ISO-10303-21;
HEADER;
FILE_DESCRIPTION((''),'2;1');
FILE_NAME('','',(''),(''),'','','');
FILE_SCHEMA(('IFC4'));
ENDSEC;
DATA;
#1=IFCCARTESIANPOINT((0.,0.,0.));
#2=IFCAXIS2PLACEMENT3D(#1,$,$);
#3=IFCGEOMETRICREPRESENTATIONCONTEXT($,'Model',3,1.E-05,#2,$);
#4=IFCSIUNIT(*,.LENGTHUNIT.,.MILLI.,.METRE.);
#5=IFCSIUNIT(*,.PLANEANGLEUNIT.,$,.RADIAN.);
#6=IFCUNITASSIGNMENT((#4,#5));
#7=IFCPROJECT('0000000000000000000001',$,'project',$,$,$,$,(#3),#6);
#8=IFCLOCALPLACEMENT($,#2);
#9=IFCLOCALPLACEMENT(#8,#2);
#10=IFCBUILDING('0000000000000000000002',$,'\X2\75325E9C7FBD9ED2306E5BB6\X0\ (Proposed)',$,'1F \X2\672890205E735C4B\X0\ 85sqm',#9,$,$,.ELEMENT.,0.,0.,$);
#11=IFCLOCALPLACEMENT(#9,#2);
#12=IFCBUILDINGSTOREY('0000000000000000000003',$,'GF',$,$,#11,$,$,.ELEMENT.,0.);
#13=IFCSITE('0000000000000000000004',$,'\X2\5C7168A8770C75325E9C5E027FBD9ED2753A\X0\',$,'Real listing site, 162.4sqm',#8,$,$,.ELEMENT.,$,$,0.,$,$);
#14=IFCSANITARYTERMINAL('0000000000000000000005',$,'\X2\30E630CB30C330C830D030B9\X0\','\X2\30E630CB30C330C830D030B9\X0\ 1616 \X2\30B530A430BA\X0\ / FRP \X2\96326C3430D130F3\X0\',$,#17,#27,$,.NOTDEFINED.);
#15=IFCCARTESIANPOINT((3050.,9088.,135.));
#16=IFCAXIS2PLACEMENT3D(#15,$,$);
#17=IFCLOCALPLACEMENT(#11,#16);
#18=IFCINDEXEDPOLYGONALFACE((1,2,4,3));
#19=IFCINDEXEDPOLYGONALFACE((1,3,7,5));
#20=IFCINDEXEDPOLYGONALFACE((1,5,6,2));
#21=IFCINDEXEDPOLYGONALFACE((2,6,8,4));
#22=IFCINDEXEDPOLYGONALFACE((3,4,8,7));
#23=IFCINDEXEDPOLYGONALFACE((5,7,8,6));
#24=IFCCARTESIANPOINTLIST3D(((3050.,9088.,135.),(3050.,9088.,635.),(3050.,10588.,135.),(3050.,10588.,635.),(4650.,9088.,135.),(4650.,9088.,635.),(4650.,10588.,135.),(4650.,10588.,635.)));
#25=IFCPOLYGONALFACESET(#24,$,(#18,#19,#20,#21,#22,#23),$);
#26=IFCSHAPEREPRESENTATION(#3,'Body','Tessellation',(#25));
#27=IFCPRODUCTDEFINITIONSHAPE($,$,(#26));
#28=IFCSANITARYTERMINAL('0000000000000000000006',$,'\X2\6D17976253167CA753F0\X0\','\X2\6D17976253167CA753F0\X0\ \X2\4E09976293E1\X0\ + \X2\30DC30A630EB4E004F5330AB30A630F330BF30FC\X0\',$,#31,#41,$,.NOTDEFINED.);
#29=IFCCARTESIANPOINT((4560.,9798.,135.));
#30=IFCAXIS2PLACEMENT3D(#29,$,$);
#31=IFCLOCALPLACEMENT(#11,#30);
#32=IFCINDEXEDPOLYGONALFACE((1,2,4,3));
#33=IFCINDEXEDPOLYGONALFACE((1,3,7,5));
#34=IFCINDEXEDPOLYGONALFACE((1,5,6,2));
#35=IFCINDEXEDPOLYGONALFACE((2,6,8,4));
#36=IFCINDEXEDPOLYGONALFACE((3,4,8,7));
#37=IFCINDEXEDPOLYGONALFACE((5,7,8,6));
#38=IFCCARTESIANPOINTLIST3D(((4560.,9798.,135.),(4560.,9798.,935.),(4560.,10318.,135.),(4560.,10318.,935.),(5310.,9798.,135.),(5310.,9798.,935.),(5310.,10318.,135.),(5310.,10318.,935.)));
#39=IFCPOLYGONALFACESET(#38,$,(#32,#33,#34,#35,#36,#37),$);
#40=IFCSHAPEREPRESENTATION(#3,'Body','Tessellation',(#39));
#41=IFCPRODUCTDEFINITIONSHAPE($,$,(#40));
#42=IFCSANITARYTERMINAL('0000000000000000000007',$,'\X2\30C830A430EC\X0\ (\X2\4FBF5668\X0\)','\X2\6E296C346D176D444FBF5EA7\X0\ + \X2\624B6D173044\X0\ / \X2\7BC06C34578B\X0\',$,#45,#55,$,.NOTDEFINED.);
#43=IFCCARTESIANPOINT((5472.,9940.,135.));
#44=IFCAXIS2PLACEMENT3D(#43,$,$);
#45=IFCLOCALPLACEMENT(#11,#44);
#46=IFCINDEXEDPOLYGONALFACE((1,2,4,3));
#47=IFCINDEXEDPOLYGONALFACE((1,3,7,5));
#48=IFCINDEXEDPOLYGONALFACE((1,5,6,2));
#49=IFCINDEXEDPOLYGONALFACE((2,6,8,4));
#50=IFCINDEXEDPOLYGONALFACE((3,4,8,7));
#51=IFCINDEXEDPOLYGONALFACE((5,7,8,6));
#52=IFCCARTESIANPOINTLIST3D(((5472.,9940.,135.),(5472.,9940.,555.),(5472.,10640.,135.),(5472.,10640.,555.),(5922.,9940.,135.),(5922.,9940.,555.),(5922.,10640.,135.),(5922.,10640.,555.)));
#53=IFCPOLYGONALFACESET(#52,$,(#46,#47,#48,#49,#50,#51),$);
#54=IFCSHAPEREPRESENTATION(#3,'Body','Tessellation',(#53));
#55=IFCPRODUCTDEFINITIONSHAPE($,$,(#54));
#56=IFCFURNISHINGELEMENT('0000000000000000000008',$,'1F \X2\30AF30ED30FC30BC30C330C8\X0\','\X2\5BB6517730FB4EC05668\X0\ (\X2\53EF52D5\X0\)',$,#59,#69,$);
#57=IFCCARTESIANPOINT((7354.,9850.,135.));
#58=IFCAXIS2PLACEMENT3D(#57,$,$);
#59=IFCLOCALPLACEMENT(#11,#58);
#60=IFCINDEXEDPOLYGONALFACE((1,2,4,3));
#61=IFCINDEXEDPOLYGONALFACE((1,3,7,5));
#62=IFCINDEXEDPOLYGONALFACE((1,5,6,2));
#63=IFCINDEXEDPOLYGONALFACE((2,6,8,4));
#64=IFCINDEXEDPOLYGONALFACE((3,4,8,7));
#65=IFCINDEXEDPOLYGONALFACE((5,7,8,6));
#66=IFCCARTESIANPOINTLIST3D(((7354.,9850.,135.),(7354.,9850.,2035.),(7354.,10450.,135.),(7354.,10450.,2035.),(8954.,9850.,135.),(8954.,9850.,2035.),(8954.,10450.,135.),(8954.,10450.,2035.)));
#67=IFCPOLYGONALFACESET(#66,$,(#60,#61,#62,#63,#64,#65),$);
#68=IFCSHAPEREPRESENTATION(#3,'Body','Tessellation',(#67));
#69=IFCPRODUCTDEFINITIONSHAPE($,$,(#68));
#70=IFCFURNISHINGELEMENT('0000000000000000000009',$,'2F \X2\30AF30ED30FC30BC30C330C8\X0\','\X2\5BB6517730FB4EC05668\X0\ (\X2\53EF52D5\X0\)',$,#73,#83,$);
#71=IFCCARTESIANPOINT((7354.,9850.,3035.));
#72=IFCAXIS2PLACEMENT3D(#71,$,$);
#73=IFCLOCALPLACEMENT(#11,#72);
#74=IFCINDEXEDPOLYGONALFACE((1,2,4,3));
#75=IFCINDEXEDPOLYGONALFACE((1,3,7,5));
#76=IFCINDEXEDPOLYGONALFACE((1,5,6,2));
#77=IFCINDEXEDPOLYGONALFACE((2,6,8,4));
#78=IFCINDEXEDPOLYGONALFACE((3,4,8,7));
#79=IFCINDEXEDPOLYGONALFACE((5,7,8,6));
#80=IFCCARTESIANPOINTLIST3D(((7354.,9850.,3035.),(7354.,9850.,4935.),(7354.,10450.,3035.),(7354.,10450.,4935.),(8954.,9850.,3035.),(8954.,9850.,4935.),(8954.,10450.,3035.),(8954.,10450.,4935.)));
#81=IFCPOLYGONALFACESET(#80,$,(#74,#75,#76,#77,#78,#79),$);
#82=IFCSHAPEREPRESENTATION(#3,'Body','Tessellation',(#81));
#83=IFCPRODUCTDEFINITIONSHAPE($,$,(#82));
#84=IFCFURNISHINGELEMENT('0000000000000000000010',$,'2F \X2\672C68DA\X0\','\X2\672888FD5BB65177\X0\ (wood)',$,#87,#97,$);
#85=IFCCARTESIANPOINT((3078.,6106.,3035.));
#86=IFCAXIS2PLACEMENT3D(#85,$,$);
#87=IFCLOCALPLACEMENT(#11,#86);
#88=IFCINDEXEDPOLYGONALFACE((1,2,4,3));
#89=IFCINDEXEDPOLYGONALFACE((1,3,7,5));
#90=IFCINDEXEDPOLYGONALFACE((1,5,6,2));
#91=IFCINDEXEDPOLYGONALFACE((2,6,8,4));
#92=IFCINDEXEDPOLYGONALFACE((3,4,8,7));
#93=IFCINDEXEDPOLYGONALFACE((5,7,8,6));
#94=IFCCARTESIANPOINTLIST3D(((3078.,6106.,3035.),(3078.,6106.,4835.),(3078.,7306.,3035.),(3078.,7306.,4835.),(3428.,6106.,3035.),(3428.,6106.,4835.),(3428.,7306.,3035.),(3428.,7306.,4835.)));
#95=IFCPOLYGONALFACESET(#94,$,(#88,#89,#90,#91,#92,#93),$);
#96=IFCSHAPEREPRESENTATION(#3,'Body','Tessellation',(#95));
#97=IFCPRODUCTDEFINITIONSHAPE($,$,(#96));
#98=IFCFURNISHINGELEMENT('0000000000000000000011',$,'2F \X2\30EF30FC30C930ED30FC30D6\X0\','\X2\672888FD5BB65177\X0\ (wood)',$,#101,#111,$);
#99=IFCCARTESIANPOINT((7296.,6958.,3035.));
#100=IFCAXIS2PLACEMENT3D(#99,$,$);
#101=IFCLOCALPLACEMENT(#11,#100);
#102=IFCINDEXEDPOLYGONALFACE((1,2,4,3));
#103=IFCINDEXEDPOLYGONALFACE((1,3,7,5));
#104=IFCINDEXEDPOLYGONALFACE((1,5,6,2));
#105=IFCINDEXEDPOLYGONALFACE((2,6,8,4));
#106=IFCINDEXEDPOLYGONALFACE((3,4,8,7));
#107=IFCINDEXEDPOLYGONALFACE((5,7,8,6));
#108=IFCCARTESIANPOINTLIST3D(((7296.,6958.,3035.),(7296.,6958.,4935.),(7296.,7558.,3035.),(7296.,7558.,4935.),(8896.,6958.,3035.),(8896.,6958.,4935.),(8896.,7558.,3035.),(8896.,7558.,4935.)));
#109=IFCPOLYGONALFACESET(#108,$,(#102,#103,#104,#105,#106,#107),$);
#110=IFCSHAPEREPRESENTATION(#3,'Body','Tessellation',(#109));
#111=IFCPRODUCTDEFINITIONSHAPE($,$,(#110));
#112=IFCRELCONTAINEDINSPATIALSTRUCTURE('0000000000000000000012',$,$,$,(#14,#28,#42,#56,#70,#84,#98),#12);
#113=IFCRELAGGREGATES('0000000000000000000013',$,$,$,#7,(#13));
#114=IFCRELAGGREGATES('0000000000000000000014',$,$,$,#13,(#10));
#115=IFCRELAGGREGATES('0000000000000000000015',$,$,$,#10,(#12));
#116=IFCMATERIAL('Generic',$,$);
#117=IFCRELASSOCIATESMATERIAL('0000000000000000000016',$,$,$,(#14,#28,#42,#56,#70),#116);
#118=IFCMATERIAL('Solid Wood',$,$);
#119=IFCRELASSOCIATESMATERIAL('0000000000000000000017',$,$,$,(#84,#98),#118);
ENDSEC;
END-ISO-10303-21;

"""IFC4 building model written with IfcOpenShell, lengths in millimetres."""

from ifc_helpers import new_model, si_unit, frame, frame_2d, origin, place, context, project, spatial, rectangle, extrude, material, element, save


model = new_model("IFC4")

# Units and contexts
model_context = context("Model", 3, precision=1e-05, world=origin())
ifc_project = project(units=[si_unit("LENGTHUNIT", "METRE", prefix="MILLI"), si_unit("PLANEANGLEUNIT", "RADIAN")], contexts=[model_context])

# Site, building, storey
site_placement = place(None, origin())
site = spatial("IfcSite", under=ifc_project, at=site_placement, Name="山梨県甲府市羽黒町", ObjectType="Real listing site, 162.4sqm", CompositionType="ELEMENT", RefElevation=0.0)
building_placement = place(site_placement, origin())
building = spatial("IfcBuilding", under=site, at=building_placement, Name="甲府羽黒の家 (Proposed)", ObjectType="1F 木造平屋 85sqm", CompositionType="ELEMENT", ElevationOfRefHeight=0.0, ElevationOfTerrain=0.0)
storey_placement = place(building_placement, origin())
storey = spatial("IfcBuildingStorey", under=building, at=storey_placement, Name="GF", CompositionType="ELEMENT", Elevation=0.0)

# Shared definitions
ifc_material_1 = material(Name="Solid Wood")

# Shared definitions
ifc_material_2 = material(Name="Generic")

# Sanitary terminals
sanitary_terminal_1_placement = place(storey_placement, frame((3050.0, 9088.0, 135.0)))
element("IfcSanitaryTerminal", 1, at=sanitary_terminal_1_placement, inside=storey, material=ifc_material_2, Name="ユニットバス", Description="ユニットバス 1616 サイズ / FRP 防水パン", PredefinedType="NOTDEFINED", context=model_context, shape_type="SweptSolid", body=[
    extrude(rectangle(XDim=1600.0, YDim=1500.0, at=frame_2d((800.0, 750.0))), frame((3050.0, 9088.0, 135.0)), (0.0, 0.0, 1.0), 500.0),
])
sanitary_terminal_2_placement = place(storey_placement, frame((4560.0, 9798.0, 135.0)))
element("IfcSanitaryTerminal", 2, at=sanitary_terminal_2_placement, inside=storey, material=ifc_material_2, Name="洗面化粧台", Description="洗面化粧台 三面鏡 + ボウル一体カウンター", PredefinedType="NOTDEFINED", context=model_context, shape_type="SweptSolid", body=[
    extrude(rectangle(XDim=750.0, YDim=520.0, at=frame_2d((375.0, 260.0))), frame((4560.0, 9798.0, 135.0)), (0.0, 0.0, 1.0), 800.0),
])
sanitary_terminal_3_placement = place(storey_placement, frame((5472.0, 9940.0, 135.0)))
element("IfcSanitaryTerminal", 3, at=sanitary_terminal_3_placement, inside=storey, material=ifc_material_2, Name="トイレ (便器)", Description="温水洗浄便座 + 手洗い / 節水型", PredefinedType="NOTDEFINED", context=model_context, shape_type="SweptSolid", body=[
    extrude(rectangle(XDim=450.0, YDim=700.0, at=frame_2d((225.0, 350.0))), frame((5472.0, 9940.0, 135.0)), (0.0, 0.0, 1.0), 420.0),
])

# Furnishing elements
furnishing_1_placement = place(storey_placement, frame((7354.0, 9850.0, 135.0)))
element("IfcFurnishingElement", 4, at=furnishing_1_placement, inside=storey, material=ifc_material_2, Name="1F クローゼット", Description="家具・什器 (可動)", context=model_context, shape_type="SweptSolid", body=[
    extrude(rectangle(XDim=1600.0, YDim=600.0, at=frame_2d((800.0, 300.0))), frame((7354.0, 9850.0, 135.0)), (0.0, 0.0, 1.0), 1900.0),
])
furnishing_2_placement = place(storey_placement, frame((7354.0, 9850.0, 3035.0)))
element("IfcFurnishingElement", 5, at=furnishing_2_placement, inside=storey, material=ifc_material_2, Name="2F クローゼット", Description="家具・什器 (可動)", context=model_context, shape_type="SweptSolid", body=[
    extrude(rectangle(XDim=1600.0, YDim=600.0, at=frame_2d((800.0, 300.0))), frame((7354.0, 9850.0, 3035.0)), (0.0, 0.0, 1.0), 1900.0),
])
furnishing_3_placement = place(storey_placement, frame((3078.0, 6106.0, 3035.0)))
element("IfcFurnishingElement", 6, at=furnishing_3_placement, inside=storey, material=ifc_material_1, Name="2F 本棚", Description="木製家具 (wood)", context=model_context, shape_type="SweptSolid", body=[
    extrude(rectangle(XDim=350.0, YDim=1200.0, at=frame_2d((175.0, 600.0))), frame((3078.0, 6106.0, 3035.0)), (0.0, 0.0, 1.0), 1800.0),
])
furnishing_4_placement = place(storey_placement, frame((7296.0, 6958.0, 3035.0)))
element("IfcFurnishingElement", 7, at=furnishing_4_placement, inside=storey, material=ifc_material_1, Name="2F ワードローブ", Description="木製家具 (wood)", context=model_context, shape_type="SweptSolid", body=[
    extrude(rectangle(XDim=1600.0, YDim=600.0, at=frame_2d((800.0, 300.0))), frame((7296.0, 6958.0, 3035.0)), (0.0, 0.0, 1.0), 1900.0),
])

save(model, "model.ifc")
